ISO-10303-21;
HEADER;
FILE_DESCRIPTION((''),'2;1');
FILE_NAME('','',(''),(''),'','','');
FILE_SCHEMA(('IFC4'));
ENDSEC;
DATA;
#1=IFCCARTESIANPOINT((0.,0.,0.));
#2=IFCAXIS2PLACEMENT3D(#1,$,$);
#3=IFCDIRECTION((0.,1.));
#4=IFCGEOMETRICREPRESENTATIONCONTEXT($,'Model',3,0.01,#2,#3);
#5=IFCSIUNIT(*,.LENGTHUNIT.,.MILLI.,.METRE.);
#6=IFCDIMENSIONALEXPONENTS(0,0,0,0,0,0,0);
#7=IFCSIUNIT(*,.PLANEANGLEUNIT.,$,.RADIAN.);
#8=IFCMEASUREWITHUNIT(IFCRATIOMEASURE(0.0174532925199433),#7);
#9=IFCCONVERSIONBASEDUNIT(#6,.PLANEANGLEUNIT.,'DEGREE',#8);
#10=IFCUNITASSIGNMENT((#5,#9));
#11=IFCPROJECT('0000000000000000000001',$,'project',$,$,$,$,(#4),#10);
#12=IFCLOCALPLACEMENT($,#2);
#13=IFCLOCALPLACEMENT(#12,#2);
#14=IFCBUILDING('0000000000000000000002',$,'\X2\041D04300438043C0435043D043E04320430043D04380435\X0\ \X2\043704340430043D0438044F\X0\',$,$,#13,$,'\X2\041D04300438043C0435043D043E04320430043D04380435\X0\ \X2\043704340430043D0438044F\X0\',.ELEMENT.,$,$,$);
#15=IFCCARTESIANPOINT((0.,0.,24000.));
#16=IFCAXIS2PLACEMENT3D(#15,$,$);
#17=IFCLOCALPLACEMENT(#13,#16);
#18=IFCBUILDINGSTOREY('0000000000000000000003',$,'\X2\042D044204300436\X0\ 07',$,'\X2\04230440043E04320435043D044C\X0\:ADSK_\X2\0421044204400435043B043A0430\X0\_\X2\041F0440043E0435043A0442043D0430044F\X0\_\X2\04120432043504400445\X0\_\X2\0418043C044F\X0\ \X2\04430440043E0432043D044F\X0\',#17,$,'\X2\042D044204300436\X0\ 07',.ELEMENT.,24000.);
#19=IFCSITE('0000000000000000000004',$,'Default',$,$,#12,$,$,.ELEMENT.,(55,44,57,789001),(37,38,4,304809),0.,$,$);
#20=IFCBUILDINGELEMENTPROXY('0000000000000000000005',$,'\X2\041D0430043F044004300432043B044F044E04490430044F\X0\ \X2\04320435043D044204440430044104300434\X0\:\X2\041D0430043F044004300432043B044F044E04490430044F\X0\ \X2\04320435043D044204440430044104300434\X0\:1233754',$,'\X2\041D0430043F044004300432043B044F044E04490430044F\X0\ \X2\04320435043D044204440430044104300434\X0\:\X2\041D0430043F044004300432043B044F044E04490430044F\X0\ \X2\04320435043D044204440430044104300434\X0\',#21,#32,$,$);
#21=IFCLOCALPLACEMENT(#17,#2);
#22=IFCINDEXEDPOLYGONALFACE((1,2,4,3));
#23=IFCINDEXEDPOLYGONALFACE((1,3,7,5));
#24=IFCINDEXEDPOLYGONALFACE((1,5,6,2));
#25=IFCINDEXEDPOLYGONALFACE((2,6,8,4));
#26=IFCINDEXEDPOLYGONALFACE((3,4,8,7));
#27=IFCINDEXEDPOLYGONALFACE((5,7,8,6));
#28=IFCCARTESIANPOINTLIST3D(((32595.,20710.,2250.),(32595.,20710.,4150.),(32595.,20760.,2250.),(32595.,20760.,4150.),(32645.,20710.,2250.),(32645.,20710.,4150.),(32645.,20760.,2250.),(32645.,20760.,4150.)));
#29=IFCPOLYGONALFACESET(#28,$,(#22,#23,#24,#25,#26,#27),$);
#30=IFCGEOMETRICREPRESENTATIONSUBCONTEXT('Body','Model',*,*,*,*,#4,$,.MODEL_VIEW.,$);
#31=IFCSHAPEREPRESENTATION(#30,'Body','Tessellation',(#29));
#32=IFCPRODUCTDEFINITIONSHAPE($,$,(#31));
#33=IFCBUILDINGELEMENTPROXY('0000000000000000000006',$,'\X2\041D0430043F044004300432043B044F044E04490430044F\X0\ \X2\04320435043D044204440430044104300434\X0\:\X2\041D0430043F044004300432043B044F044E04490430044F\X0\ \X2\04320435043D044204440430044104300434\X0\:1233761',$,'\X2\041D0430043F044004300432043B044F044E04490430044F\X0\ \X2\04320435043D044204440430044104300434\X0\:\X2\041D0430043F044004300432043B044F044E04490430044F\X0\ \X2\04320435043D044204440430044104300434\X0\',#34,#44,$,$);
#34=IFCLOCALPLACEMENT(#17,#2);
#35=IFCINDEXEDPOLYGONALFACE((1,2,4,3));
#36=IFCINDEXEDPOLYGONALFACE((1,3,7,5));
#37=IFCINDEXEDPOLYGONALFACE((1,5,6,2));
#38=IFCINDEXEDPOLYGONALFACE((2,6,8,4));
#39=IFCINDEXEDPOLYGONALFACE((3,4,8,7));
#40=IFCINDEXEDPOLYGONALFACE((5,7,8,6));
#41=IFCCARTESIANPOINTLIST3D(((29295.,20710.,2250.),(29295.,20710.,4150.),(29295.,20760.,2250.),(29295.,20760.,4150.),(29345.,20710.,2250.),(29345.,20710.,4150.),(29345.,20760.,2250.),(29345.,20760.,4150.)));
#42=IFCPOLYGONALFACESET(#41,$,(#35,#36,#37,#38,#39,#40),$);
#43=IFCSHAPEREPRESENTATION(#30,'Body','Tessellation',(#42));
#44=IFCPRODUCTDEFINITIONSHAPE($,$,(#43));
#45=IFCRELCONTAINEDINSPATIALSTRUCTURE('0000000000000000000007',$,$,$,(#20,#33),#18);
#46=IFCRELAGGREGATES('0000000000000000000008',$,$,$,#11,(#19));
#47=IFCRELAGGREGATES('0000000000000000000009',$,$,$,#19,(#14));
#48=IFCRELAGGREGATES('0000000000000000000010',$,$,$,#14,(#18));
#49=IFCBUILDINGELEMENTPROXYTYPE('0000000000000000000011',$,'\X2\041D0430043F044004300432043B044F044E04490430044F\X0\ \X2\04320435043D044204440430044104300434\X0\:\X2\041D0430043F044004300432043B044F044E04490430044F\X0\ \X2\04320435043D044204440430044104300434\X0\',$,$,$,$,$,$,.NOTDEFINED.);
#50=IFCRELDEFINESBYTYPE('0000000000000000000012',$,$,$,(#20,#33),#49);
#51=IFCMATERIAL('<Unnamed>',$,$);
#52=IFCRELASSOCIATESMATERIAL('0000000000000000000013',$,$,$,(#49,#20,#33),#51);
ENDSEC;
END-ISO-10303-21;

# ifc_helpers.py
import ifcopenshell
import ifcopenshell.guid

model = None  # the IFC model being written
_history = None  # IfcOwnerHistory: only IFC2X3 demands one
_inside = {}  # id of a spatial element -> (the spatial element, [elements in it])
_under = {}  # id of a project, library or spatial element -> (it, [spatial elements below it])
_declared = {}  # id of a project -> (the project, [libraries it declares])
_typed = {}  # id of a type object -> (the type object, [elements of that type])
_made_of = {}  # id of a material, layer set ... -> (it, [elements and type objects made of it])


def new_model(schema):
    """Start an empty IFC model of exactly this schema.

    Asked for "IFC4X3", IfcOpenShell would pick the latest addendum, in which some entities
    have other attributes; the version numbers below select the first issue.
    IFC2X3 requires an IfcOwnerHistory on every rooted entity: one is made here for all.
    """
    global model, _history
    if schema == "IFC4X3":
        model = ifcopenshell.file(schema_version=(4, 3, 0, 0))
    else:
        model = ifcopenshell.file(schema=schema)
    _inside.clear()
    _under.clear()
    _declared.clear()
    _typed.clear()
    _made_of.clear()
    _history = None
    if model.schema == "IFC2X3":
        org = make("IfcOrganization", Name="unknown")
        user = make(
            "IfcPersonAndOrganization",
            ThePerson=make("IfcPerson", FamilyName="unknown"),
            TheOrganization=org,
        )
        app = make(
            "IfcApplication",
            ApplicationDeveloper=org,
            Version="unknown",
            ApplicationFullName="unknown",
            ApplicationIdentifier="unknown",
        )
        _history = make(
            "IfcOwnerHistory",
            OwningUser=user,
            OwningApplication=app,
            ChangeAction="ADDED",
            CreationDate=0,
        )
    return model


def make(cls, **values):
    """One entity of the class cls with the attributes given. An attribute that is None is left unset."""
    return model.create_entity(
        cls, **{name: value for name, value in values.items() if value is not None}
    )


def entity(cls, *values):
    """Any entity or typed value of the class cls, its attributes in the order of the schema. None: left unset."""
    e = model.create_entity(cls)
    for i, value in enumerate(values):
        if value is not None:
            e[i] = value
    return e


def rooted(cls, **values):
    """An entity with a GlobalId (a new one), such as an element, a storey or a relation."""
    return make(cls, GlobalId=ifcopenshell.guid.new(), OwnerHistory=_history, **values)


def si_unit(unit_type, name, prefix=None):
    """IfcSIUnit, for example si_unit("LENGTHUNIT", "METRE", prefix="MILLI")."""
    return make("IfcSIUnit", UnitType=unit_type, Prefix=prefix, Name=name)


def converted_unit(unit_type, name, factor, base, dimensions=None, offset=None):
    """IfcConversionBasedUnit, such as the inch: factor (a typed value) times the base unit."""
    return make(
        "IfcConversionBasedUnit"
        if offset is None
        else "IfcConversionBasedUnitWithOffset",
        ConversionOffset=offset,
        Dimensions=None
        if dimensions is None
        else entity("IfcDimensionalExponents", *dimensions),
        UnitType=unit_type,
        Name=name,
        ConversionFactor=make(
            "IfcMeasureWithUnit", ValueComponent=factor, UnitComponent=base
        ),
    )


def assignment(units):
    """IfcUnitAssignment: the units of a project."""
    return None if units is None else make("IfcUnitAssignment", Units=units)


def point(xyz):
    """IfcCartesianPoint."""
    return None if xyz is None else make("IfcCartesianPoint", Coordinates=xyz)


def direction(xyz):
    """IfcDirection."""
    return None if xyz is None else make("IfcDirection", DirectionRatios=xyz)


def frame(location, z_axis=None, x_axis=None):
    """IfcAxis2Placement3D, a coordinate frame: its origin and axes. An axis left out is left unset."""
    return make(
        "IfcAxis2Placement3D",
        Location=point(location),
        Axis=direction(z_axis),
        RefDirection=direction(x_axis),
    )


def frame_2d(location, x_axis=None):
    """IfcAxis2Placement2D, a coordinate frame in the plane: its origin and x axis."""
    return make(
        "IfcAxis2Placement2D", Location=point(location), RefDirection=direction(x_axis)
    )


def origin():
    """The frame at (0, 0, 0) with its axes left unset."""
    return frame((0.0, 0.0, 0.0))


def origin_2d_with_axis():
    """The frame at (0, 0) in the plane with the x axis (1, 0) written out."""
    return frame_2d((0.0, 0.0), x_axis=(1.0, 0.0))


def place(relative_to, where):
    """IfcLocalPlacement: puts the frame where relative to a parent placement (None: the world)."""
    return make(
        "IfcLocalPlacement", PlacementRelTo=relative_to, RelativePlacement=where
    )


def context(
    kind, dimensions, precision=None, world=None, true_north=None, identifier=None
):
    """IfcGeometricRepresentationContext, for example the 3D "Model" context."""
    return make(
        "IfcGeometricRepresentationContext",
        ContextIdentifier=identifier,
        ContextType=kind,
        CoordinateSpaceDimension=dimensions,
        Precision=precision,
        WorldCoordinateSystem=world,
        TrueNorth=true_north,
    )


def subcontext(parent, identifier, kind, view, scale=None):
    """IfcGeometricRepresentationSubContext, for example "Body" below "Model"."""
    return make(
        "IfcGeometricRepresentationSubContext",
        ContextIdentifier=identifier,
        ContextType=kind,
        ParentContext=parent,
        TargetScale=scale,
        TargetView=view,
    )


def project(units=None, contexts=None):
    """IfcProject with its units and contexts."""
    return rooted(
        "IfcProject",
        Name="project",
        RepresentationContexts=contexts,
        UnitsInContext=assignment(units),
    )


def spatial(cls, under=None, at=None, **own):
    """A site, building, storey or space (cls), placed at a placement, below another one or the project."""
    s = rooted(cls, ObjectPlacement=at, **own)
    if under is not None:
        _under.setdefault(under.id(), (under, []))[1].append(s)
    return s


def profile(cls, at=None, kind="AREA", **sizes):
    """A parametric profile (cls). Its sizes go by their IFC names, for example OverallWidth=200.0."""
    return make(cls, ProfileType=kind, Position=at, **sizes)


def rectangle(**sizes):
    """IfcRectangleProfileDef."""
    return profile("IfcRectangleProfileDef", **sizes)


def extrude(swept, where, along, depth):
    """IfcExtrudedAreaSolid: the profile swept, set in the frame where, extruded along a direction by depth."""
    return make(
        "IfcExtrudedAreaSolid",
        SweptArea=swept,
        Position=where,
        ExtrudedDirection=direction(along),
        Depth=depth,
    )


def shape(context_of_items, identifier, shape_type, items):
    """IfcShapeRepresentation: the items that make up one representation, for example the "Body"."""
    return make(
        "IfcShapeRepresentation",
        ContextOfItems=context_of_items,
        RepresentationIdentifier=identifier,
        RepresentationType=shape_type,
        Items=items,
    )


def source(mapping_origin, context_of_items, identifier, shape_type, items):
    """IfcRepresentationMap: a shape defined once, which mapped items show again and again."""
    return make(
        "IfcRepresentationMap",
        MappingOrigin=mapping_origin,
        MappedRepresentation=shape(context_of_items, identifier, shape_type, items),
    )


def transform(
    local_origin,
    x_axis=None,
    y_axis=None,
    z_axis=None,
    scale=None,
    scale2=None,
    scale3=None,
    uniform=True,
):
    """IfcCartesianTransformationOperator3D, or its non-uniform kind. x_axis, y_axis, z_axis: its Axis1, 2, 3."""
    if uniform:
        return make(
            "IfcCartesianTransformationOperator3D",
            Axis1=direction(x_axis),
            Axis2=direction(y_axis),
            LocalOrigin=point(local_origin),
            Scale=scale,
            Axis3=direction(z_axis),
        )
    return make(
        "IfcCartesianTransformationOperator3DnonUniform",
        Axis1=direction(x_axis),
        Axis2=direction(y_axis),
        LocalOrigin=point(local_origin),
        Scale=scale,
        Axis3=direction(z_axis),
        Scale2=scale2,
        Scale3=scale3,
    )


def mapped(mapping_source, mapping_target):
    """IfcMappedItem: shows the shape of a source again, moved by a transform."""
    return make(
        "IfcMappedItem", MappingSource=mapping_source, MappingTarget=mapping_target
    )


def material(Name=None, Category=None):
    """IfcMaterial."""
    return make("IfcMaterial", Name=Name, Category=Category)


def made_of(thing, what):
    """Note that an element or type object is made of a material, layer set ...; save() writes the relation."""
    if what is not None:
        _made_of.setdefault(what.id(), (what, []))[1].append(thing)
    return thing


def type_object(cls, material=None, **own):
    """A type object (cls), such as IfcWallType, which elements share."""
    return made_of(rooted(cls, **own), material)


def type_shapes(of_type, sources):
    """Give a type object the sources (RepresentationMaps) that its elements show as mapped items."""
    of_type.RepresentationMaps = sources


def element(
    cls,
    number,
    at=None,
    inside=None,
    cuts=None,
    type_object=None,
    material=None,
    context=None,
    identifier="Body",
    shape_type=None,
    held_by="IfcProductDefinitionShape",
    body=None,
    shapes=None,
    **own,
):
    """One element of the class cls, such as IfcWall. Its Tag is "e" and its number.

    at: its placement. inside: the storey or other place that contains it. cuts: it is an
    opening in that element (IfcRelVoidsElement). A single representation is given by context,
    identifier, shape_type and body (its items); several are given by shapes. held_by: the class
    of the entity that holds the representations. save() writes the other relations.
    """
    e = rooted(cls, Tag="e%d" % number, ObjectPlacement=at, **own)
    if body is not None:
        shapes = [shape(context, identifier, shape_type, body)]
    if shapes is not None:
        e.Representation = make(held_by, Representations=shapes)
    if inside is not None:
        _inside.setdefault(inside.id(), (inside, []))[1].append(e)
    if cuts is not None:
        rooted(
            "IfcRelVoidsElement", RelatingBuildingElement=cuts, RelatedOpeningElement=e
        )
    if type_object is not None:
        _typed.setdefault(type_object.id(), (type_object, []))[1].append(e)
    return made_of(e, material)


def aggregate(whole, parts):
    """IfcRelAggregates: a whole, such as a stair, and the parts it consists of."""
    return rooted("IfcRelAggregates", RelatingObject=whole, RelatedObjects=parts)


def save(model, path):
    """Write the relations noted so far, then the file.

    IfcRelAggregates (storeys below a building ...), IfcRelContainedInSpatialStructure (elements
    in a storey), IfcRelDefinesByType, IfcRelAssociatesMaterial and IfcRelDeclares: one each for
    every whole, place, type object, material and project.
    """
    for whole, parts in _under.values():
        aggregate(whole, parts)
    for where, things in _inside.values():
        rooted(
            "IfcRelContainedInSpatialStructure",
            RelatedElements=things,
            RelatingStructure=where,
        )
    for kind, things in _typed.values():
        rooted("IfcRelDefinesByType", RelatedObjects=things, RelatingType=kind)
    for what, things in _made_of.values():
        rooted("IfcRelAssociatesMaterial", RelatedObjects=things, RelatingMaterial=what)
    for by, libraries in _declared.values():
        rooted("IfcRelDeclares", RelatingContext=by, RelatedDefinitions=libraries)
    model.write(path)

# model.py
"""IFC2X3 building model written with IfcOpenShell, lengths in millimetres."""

from ifc_helpers import new_model, entity, si_unit, converted_unit, direction, frame, origin, origin_2d_with_axis, place, context, subcontext, project, spatial, rectangle, extrude, source, transform, mapped, material, type_object, type_shapes, element, save


model = new_model("IFC2X3")

# Units and contexts
model_context = context("Model", 3, precision=0.01, world=origin(), true_north=direction((0.0, 1.0)))
body_context = subcontext(model_context, "Body", "Model", "MODEL_VIEW")
ifc_project = project(units=[si_unit("LENGTHUNIT", "METRE", prefix="MILLI"), converted_unit("PLANEANGLEUNIT", "DEGREE", entity("IfcRatioMeasure", 0.0174532925199433), si_unit("PLANEANGLEUNIT", "RADIAN"), dimensions=[0, 0, 0, 0, 0, 0, 0])], contexts=[model_context])

# Site, building, storey
site_placement = place(None, origin())
site = spatial("IfcSite", under=ifc_project, at=site_placement, Name="Default", CompositionType="ELEMENT", RefLatitude=(55, 44, 57, 789001), RefLongitude=(37, 38, 4, 304809), RefElevation=0.0)
building_placement = place(site_placement, origin())
building = spatial("IfcBuilding", under=site, at=building_placement, Name="Наименование здания", LongName="Наименование здания", CompositionType="ELEMENT")
storey_placement = place(building_placement, frame((0.0, 0.0, 24000.0)))
storey = spatial("IfcBuildingStorey", under=building, at=storey_placement, Name="Этаж 07", ObjectType="Уровень:ADSK_Стрелка_Проектная_Вверх_Имя уровня", LongName="Этаж 07", CompositionType="ELEMENT", Elevation=24000.0)

# Building element proxies
ifc_material_1 = material(Name="<Unnamed>")
building_element_proxy_type_1 = type_object("IfcBuildingElementProxyType", Name="Направляющая вентфасад:Направляющая вентфасад", PredefinedType="NOTDEFINED", material=ifc_material_1)
shared_shape_1 = source(origin(), body_context, "Body", "SweptSolid", [
    extrude(rectangle(XDim=50.0, YDim=50.0, at=origin_2d_with_axis()), frame((25.0, -25.0, 0.0), z_axis=(0.0, 0.0, 1.0), x_axis=(-1.0, 0.0, 0.0)), (0.0, 0.0, 1.0), 1900.0),
])
type_shapes(building_element_proxy_type_1, [shared_shape_1])
for number, where, z_axis, x_axis, name in (
    (1, (32645.0, 20710.0, 2250.0), (0.0, 0.0, 1.0), (-1.0, 0.0, 0.0), "Направляющая вентфасад:Направляющая вентфасад:1233754"),
    (2, (29345.0, 20710.0, 2250.0), (0.0, 0.0, 1.0), (-1.0, 0.0, 0.0), "Направляющая вентфасад:Направляющая вентфасад:1233761"),
):
    element("IfcBuildingElementProxy", number, at=place(storey_placement, frame(where, z_axis=z_axis, x_axis=x_axis)), inside=storey, type_object=building_element_proxy_type_1, material=ifc_material_1, Name=name, ObjectType="Направляющая вентфасад:Направляющая вентфасад", context=body_context, shape_type="MappedRepresentation", body=[
        mapped(shared_shape_1, transform((0.0, 0.0, 0.0), scale=1.0)),
    ])

save(model, "model.ifc")
